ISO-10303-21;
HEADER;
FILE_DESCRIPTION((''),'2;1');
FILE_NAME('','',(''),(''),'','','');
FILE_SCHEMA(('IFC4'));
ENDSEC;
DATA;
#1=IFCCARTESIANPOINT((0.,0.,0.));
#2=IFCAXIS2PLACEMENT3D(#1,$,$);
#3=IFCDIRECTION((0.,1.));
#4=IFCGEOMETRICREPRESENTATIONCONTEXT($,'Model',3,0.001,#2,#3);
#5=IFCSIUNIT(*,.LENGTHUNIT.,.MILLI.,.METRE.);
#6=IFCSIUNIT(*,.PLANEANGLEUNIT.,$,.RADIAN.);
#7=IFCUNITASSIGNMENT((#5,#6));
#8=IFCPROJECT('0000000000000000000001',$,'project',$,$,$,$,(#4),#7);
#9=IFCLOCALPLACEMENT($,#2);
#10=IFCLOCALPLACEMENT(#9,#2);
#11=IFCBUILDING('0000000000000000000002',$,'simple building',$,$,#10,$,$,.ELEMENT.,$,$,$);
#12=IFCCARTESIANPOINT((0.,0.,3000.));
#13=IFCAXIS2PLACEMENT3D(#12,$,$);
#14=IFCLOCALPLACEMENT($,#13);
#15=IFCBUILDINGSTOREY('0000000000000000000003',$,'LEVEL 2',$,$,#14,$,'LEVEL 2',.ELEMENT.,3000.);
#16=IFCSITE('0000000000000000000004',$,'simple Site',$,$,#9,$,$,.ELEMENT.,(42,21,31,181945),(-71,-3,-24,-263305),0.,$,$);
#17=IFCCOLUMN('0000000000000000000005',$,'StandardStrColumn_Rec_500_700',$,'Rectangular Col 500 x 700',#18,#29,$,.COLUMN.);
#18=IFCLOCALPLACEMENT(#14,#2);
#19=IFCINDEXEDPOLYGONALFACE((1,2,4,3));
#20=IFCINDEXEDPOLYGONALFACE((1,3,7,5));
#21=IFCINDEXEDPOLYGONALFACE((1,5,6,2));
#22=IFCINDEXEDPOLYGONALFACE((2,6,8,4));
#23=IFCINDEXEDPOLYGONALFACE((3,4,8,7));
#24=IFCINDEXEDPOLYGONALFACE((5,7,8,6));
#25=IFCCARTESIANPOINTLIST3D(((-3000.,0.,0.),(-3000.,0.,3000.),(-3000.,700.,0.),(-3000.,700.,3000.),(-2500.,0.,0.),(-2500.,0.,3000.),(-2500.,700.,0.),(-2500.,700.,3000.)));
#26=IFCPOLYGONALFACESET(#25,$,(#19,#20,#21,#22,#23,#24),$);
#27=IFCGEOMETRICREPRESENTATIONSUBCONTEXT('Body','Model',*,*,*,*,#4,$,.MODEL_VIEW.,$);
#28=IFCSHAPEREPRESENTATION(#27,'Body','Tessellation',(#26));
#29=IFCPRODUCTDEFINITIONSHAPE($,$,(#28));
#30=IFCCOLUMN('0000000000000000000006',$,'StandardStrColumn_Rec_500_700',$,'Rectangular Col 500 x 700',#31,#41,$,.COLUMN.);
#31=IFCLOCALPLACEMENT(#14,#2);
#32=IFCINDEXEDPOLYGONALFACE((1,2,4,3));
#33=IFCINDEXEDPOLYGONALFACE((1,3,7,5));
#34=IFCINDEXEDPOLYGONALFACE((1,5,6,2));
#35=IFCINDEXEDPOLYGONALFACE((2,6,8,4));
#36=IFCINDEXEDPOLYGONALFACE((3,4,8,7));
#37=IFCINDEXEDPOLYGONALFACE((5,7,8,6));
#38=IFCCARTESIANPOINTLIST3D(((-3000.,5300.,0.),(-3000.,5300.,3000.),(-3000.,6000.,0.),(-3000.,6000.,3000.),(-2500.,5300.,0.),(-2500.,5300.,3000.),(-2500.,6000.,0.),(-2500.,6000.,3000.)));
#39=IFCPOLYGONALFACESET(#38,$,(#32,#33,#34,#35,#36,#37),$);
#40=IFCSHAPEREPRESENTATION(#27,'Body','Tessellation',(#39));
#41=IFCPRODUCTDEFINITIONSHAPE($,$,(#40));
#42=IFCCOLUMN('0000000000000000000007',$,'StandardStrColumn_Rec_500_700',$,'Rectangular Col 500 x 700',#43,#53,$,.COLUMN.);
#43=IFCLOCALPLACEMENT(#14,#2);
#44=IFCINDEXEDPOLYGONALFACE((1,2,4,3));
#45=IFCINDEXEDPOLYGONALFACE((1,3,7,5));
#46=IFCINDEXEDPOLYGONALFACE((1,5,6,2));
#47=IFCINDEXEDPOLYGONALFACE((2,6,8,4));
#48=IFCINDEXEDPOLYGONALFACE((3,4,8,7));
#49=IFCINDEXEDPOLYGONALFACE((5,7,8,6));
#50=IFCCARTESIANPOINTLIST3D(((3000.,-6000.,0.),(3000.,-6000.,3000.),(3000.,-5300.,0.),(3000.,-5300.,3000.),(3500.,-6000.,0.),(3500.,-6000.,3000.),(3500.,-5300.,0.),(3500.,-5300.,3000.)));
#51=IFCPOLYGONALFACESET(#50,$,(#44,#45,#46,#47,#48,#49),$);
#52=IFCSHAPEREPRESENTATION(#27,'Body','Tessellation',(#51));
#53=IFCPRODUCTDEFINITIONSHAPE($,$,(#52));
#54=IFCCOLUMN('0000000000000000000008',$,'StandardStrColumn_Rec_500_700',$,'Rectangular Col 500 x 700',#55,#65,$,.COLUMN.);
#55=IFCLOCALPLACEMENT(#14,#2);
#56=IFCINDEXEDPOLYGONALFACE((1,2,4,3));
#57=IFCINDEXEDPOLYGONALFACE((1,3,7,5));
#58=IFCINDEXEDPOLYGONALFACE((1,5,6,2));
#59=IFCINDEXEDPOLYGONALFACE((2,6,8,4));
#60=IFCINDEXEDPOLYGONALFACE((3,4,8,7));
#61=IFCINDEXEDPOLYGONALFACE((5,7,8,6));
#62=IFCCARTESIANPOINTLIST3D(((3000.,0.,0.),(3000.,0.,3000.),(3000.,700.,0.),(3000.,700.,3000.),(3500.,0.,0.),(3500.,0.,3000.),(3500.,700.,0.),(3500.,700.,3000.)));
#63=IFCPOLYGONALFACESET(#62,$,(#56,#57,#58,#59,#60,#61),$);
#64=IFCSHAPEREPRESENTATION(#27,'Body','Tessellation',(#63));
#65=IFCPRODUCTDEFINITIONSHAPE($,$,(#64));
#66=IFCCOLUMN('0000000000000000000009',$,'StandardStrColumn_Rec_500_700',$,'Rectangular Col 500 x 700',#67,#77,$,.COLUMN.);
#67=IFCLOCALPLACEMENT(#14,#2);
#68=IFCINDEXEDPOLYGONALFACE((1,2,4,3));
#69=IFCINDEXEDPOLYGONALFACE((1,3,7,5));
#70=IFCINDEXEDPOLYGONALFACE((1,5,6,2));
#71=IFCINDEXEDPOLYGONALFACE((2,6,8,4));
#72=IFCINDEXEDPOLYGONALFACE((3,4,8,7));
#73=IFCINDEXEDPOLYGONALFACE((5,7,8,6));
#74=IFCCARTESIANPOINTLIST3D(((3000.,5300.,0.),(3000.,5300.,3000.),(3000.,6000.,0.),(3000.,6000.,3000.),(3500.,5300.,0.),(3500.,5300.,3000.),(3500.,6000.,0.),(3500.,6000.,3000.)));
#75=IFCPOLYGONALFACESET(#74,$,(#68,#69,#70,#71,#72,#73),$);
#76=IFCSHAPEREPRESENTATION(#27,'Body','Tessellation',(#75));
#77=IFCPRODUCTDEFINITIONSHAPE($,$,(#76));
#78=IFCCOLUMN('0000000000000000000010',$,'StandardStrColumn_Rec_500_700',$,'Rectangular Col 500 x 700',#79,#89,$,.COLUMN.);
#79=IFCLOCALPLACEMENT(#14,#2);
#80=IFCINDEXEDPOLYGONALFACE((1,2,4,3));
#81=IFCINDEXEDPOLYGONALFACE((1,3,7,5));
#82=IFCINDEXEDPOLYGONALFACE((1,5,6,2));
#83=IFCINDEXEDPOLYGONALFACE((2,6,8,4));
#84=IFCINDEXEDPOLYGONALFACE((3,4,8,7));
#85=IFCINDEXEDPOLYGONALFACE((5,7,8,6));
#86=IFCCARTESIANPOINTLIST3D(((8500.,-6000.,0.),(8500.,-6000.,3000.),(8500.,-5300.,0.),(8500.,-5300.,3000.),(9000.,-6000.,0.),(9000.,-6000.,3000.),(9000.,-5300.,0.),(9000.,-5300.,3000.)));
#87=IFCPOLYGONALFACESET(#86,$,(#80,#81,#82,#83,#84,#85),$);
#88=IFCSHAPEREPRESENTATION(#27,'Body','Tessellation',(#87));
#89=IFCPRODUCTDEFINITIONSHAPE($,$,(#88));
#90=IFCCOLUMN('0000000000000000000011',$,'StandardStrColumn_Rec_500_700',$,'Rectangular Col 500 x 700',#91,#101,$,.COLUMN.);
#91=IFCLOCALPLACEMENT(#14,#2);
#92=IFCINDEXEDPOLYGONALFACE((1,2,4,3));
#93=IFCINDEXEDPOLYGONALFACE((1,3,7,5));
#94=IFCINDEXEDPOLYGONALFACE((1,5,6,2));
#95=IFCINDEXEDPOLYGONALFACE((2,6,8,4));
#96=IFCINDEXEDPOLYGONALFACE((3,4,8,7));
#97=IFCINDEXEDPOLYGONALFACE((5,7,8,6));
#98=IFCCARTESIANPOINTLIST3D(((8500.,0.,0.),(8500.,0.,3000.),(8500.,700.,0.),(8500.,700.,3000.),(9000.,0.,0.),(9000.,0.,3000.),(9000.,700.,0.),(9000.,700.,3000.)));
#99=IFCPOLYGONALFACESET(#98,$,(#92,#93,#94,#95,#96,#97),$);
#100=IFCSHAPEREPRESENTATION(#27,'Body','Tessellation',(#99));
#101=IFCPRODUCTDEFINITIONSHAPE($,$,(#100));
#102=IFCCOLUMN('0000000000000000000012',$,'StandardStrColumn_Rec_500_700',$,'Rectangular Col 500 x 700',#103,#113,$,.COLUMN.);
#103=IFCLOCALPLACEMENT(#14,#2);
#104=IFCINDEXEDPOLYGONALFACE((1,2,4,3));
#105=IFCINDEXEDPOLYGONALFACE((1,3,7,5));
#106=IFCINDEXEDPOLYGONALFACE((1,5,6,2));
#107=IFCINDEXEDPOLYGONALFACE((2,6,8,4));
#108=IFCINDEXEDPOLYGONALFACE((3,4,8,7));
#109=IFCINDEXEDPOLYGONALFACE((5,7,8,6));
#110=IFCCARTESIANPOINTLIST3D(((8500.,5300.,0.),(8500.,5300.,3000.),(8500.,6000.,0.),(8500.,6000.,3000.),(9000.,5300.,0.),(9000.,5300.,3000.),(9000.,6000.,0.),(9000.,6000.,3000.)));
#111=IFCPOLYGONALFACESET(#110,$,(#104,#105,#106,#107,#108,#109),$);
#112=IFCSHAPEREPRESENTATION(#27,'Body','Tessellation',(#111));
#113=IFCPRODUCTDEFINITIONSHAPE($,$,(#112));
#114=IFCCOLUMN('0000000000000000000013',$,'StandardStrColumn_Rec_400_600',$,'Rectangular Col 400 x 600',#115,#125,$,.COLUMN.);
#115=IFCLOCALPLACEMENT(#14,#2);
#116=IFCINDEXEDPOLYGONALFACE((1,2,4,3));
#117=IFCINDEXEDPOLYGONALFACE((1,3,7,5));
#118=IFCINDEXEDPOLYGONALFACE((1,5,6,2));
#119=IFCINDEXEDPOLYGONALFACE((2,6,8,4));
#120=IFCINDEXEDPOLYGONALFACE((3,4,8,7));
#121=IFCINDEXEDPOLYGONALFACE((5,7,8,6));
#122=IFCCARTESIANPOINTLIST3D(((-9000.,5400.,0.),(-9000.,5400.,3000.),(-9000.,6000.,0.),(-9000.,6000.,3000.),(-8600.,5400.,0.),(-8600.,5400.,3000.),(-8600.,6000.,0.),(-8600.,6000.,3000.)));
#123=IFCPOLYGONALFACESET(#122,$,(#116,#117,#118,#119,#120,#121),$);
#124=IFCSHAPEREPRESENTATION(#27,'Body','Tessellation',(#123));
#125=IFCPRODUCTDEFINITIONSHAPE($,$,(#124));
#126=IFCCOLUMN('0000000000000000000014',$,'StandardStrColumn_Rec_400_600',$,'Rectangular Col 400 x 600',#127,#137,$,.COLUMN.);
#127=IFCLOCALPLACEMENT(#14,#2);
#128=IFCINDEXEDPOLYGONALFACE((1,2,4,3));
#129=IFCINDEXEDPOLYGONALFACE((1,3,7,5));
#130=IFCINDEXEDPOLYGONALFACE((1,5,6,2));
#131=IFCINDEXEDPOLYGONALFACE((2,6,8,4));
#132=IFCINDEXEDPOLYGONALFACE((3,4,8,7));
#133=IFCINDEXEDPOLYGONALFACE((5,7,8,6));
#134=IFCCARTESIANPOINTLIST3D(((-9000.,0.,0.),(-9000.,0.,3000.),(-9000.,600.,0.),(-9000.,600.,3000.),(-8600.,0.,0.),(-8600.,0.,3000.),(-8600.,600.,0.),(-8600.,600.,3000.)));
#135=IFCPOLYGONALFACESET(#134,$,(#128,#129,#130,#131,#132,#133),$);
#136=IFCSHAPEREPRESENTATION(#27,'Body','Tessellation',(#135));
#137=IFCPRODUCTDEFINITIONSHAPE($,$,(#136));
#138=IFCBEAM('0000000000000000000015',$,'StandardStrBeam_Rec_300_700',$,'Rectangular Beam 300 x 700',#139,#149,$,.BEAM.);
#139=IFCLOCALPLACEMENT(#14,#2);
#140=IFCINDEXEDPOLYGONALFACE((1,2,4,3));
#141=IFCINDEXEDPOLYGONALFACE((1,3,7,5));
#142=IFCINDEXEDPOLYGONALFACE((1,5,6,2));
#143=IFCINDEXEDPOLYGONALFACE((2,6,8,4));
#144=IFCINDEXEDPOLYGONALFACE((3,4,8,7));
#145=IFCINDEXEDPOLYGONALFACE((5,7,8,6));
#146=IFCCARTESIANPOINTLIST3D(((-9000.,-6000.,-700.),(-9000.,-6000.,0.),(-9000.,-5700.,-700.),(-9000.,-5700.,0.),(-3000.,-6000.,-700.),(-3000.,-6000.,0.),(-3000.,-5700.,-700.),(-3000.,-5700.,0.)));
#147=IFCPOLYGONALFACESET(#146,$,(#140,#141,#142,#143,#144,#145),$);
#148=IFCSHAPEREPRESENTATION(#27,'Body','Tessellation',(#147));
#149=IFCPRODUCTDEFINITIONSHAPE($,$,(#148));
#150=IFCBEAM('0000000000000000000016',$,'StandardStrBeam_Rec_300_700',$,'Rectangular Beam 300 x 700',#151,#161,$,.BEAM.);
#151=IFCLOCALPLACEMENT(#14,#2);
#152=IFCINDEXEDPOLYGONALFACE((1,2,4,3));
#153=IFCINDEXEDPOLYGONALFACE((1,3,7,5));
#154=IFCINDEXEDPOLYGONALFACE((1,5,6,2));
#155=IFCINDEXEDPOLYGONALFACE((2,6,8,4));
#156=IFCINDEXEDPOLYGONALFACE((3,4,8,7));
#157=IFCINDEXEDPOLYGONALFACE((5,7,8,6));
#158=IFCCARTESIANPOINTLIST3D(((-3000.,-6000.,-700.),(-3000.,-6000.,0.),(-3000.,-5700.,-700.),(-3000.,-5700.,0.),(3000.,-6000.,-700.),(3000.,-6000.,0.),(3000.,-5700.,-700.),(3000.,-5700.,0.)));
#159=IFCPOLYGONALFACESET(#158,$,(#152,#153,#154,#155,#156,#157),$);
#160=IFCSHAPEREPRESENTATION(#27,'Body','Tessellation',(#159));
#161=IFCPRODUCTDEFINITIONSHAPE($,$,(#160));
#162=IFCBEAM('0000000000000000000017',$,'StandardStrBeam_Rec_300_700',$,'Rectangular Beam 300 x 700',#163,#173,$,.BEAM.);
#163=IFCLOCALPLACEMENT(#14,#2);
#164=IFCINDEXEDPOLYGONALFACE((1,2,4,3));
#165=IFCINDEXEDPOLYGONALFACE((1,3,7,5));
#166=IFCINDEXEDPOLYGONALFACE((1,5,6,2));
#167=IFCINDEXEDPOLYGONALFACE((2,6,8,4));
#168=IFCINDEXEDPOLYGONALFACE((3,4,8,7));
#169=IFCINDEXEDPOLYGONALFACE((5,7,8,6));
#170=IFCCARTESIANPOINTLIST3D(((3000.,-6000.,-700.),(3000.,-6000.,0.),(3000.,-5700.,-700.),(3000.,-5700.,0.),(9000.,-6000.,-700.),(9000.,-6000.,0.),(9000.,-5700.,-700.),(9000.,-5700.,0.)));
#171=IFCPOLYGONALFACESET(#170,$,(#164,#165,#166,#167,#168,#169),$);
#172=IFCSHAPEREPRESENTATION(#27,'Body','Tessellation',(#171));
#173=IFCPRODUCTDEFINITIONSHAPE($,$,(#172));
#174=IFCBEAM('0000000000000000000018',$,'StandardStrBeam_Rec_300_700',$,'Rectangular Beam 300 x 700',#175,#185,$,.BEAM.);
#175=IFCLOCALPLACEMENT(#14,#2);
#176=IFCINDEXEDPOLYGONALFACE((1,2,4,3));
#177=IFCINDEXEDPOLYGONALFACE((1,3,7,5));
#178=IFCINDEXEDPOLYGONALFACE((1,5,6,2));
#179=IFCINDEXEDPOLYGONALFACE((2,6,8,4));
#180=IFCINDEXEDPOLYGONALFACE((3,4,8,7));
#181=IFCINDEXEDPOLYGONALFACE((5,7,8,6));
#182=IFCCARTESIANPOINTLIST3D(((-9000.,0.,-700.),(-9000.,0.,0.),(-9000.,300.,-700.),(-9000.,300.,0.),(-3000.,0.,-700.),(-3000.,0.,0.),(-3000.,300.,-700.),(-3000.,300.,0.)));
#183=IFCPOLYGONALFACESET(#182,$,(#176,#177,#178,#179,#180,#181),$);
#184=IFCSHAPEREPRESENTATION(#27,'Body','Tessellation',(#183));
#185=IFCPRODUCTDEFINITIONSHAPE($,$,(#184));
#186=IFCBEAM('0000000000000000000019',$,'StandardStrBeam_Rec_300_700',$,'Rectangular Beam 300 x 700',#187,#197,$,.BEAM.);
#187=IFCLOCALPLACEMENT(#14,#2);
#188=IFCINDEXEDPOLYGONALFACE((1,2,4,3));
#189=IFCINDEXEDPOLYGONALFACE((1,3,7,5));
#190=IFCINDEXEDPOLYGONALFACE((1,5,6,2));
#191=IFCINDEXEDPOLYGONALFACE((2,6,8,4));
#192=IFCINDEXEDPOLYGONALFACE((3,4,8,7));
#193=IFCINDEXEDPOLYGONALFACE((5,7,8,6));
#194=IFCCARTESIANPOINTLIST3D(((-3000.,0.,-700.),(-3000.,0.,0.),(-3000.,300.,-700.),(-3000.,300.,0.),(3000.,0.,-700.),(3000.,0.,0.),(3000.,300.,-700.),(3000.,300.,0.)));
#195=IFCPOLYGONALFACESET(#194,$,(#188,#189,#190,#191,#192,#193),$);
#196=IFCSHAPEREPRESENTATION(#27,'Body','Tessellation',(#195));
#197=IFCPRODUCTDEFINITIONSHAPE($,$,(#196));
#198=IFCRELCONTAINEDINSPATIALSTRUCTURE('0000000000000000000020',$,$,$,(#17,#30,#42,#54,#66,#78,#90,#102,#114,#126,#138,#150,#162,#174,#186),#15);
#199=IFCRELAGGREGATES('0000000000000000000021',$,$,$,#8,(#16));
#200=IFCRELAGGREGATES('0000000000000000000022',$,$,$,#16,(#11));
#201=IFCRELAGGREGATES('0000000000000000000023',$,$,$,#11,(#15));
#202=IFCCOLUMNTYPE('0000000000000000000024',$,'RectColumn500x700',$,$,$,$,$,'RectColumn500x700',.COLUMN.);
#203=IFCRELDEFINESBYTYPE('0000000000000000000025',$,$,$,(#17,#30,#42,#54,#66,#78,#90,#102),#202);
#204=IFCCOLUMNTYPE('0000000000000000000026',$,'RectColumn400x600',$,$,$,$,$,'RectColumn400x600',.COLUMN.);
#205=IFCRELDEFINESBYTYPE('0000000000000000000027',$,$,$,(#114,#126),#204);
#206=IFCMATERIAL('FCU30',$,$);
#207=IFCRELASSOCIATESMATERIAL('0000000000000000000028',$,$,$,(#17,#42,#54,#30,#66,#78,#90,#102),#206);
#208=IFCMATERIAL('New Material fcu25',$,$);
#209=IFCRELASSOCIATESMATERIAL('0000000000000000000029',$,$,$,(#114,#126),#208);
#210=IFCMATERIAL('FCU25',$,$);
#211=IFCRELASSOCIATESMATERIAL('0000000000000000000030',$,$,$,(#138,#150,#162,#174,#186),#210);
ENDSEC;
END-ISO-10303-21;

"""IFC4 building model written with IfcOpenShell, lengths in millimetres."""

from ifc_helpers import new_model, si_unit, direction, frame, origin, origin_with_axes, origin_2d_with_axis, place, context, subcontext, project, spatial, rectangle, extrude, material, material_profile, profile_set, profile_usage, type_object, element, save


model = new_model("IFC4")

# Units and contexts
model_context = context("Model", 3, precision=0.001, world=origin(), true_north=direction((0.0, 1.0)))
body_context = subcontext(model_context, "Body", "Model", "MODEL_VIEW")
ifc_project = project(units=[si_unit("LENGTHUNIT", "METRE", prefix="MILLI"), si_unit("PLANEANGLEUNIT", "RADIAN")], contexts=[model_context])

# Site, building, storey
site_placement = place(None, origin())
site = spatial("IfcSite", under=ifc_project, at=site_placement, Name="simple Site", CompositionType="ELEMENT", RefLatitude=(42, 21, 31, 181945), RefLongitude=(-71, -3, -24, -263305), RefElevation=0.0)
building_placement = place(site_placement, origin())
building = spatial("IfcBuilding", under=site, at=building_placement, Name="simple building", CompositionType="ELEMENT")
storey_placement = place(None, frame((0.0, 0.0, 3000.0)))
storey = spatial("IfcBuildingStorey", under=building, at=storey_placement, Name="LEVEL 2", LongName="LEVEL 2", CompositionType="ELEMENT", Elevation=3000.0)

# Columns
ifc_material_1 = material(Name="FCU30")
ifc_material_profile_1 = material_profile(ifc_material_1, rectangle(XDim=500.0, YDim=700.0, at=origin_2d_with_axis()))
ifc_profile_set_1 = profile_set([ifc_material_profile_1])
ifc_profile_usage_1 = profile_usage(ifc_profile_set_1, cardinal=7)
column_type_1 = type_object("IfcColumnType", Name="RectColumn500x700", ElementType="RectColumn500x700", PredefinedType="COLUMN")
column_1_placement = place(None, frame((-2750.0, 350.0, 3000.0), z_axis=(0.0, 0.0, 1.0), x_axis=(1.0, 0.0, 0.0)))
element("IfcColumn", 1, at=column_1_placement, inside=storey, type_object=column_type_1, material=ifc_profile_usage_1, Name="StandardStrColumn_Rec_500_700", ObjectType="Rectangular Col 500 x 700", PredefinedType="COLUMN", context=body_context, shape_type="SweptSolid", body=[
    extrude(rectangle(XDim=500.0, YDim=700.0, at=origin_2d_with_axis()), origin_with_axes(), (0.0, 0.0, 1.0), 3000.0),
])
ifc_profile_usage_2 = profile_usage(ifc_profile_set_1, cardinal=1)
column_2_placement = place(None, frame((-2750.0, 5650.0, 3000.0), z_axis=(0.0, 0.0, 1.0), x_axis=(1.0, 0.0, 0.0)))
element("IfcColumn", 2, at=column_2_placement, inside=storey, type_object=column_type_1, material=ifc_profile_usage_2, Name="StandardStrColumn_Rec_500_700", ObjectType="Rectangular Col 500 x 700", PredefinedType="COLUMN", context=body_context, shape_type="SweptSolid", body=[
    extrude(rectangle(XDim=500.0, YDim=700.0, at=origin_2d_with_axis()), origin_with_axes(), (0.0, 0.0, 1.0), 3000.0),
])
for number, where, z_axis, x_axis, name in (
    (3, (3250.0, -5650.0, 3000.0), (0.0, 0.0, 1.0), (1.0, 0.0, 0.0), "StandardStrColumn_Rec_500_700"),
    (4, (3250.0, 350.0, 3000.0), (0.0, 0.0, 1.0), (1.0, 0.0, 0.0), "StandardStrColumn_Rec_500_700"),
):
    element("IfcColumn", number, at=place(None, frame(where, z_axis=z_axis, x_axis=x_axis)), inside=storey, type_object=column_type_1, material=ifc_profile_usage_1, Name=name, ObjectType="Rectangular Col 500 x 700", PredefinedType="COLUMN", context=body_context, shape_type="SweptSolid", body=[
        extrude(rectangle(XDim=500.0, YDim=700.0, at=origin_2d_with_axis()), origin_with_axes(), (0.0, 0.0, 1.0), 3000.0),
    ])
column_3_placement = place(None, frame((3250.0, 5650.0, 3000.0), z_axis=(0.0, 0.0, 1.0), x_axis=(1.0, 0.0, 0.0)))
element("IfcColumn", 5, at=column_3_placement, inside=storey, type_object=column_type_1, material=ifc_profile_usage_2, Name="StandardStrColumn_Rec_500_700", ObjectType="Rectangular Col 500 x 700", PredefinedType="COLUMN", context=body_context, shape_type="SweptSolid", body=[
    extrude(rectangle(XDim=500.0, YDim=700.0, at=origin_2d_with_axis()), origin_with_axes(), (0.0, 0.0, 1.0), 3000.0),
])
ifc_profile_usage_3 = profile_usage(ifc_profile_set_1, cardinal=9)
for number, where, z_axis, x_axis, name in (
    (6, (8750.0, -5650.0, 3000.0), (0.0, 0.0, 1.0), (1.0, 0.0, 0.0), "StandardStrColumn_Rec_500_700"),
    (7, (8750.0, 350.0, 3000.0), (0.0, 0.0, 1.0), (1.0, 0.0, 0.0), "StandardStrColumn_Rec_500_700"),
):
    element("IfcColumn", number, at=place(None, frame(where, z_axis=z_axis, x_axis=x_axis)), inside=storey, type_object=column_type_1, material=ifc_profile_usage_3, Name=name, ObjectType="Rectangular Col 500 x 700", PredefinedType="COLUMN", context=body_context, shape_type="SweptSolid", body=[
        extrude(rectangle(XDim=500.0, YDim=700.0, at=origin_2d_with_axis()), origin_with_axes(), (0.0, 0.0, 1.0), 3000.0),
    ])
ifc_profile_usage_4 = profile_usage(ifc_profile_set_1, cardinal=3)
column_4_placement = place(None, frame((8750.0, 5650.0, 3000.0), z_axis=(0.0, 0.0, 1.0), x_axis=(1.0, 0.0, 0.0)))
element("IfcColumn", 8, at=column_4_placement, inside=storey, type_object=column_type_1, material=ifc_profile_usage_4, Name="StandardStrColumn_Rec_500_700", ObjectType="Rectangular Col 500 x 700", PredefinedType="COLUMN", context=body_context, shape_type="SweptSolid", body=[
    extrude(rectangle(XDim=500.0, YDim=700.0, at=origin_2d_with_axis()), origin_with_axes(), (0.0, 0.0, 1.0), 3000.0),
])
ifc_material_2 = material(Name="New Material fcu25")
ifc_material_profile_2 = material_profile(ifc_material_2, rectangle(XDim=400.0, YDim=600.0, at=origin_2d_with_axis()))
ifc_profile_set_2 = profile_set([ifc_material_profile_2])
ifc_profile_usage_5 = profile_usage(ifc_profile_set_2, cardinal=1)
column_type_2 = type_object("IfcColumnType", Name="RectColumn400x600", ElementType="RectColumn400x600", PredefinedType="COLUMN")
column_5_placement = place(None, frame((-8800.0, 5700.0, 3000.0), z_axis=(0.0, 0.0, 1.0), x_axis=(1.0, 0.0, 0.0)))
element("IfcColumn", 9, at=column_5_placement, inside=storey, type_object=column_type_2, material=ifc_profile_usage_5, Name="StandardStrColumn_Rec_400_600", ObjectType="Rectangular Col 400 x 600", PredefinedType="COLUMN", context=body_context, shape_type="SweptSolid", body=[
    extrude(rectangle(XDim=400.0, YDim=600.0, at=origin_2d_with_axis()), origin_with_axes(), (0.0, 0.0, 1.0), 3000.0),
])
ifc_profile_usage_6 = profile_usage(ifc_profile_set_2, cardinal=7)
column_6_placement = place(None, frame((-8800.0, 300.0, 3000.0), z_axis=(0.0, 0.0, 1.0), x_axis=(1.0, 0.0, 0.0)))
element("IfcColumn", 10, at=column_6_placement, inside=storey, type_object=column_type_2, material=ifc_profile_usage_6, Name="StandardStrColumn_Rec_400_600", ObjectType="Rectangular Col 400 x 600", PredefinedType="COLUMN", context=body_context, shape_type="SweptSolid", body=[
    extrude(rectangle(XDim=400.0, YDim=600.0, at=origin_2d_with_axis()), origin_with_axes(), (0.0, 0.0, 1.0), 3000.0),
])

# Beams
ifc_material_3 = material(Name="FCU25")
ifc_material_profile_3 = material_profile(ifc_material_3, rectangle(XDim=300.0, YDim=700.0, at=origin_2d_with_axis()))
ifc_profile_set_3 = profile_set([ifc_material_profile_3])
ifc_profile_usage_7 = profile_usage(ifc_profile_set_3, cardinal=9)
for number, where, z_axis, x_axis, name in (
    (11, (-9000.0, -5850.0, 2650.0), (1.0, 0.0, 0.0), (0.0, -1.0, 0.0), "StandardStrBeam_Rec_300_700"),
    (12, (-3000.0, -5850.0, 2650.0), (1.0, 0.0, 0.0), (0.0, -1.0, 0.0), "StandardStrBeam_Rec_300_700"),
    (13, (3000.0, -5850.0, 2650.0), (1.0, 0.0, 0.0), (0.0, -1.0, 0.0), "StandardStrBeam_Rec_300_700"),
    (14, (-9000.0, 150.0, 2650.0), (1.0, 0.0, 0.0), (0.0, -1.0, 0.0), "StandardStrBeam_Rec_300_700"),
    (15, (-3000.0, 150.0, 2650.0), (1.0, 0.0, 0.0), (0.0, -1.0, 0.0), "StandardStrBeam_Rec_300_700"),
):
    element("IfcBeam", number, at=place(None, frame(where, z_axis=z_axis, x_axis=x_axis)), inside=storey, material=ifc_profile_usage_7, Name=name, ObjectType="Rectangular Beam 300 x 700", PredefinedType="BEAM", context=body_context, shape_type="SweptSolid", body=[
        extrude(rectangle(XDim=300.0, YDim=700.0, at=origin_2d_with_axis()), origin_with_axes(), (0.0, 0.0, 1.0), 6000.0),
    ])

save(model, "model.ifc")
